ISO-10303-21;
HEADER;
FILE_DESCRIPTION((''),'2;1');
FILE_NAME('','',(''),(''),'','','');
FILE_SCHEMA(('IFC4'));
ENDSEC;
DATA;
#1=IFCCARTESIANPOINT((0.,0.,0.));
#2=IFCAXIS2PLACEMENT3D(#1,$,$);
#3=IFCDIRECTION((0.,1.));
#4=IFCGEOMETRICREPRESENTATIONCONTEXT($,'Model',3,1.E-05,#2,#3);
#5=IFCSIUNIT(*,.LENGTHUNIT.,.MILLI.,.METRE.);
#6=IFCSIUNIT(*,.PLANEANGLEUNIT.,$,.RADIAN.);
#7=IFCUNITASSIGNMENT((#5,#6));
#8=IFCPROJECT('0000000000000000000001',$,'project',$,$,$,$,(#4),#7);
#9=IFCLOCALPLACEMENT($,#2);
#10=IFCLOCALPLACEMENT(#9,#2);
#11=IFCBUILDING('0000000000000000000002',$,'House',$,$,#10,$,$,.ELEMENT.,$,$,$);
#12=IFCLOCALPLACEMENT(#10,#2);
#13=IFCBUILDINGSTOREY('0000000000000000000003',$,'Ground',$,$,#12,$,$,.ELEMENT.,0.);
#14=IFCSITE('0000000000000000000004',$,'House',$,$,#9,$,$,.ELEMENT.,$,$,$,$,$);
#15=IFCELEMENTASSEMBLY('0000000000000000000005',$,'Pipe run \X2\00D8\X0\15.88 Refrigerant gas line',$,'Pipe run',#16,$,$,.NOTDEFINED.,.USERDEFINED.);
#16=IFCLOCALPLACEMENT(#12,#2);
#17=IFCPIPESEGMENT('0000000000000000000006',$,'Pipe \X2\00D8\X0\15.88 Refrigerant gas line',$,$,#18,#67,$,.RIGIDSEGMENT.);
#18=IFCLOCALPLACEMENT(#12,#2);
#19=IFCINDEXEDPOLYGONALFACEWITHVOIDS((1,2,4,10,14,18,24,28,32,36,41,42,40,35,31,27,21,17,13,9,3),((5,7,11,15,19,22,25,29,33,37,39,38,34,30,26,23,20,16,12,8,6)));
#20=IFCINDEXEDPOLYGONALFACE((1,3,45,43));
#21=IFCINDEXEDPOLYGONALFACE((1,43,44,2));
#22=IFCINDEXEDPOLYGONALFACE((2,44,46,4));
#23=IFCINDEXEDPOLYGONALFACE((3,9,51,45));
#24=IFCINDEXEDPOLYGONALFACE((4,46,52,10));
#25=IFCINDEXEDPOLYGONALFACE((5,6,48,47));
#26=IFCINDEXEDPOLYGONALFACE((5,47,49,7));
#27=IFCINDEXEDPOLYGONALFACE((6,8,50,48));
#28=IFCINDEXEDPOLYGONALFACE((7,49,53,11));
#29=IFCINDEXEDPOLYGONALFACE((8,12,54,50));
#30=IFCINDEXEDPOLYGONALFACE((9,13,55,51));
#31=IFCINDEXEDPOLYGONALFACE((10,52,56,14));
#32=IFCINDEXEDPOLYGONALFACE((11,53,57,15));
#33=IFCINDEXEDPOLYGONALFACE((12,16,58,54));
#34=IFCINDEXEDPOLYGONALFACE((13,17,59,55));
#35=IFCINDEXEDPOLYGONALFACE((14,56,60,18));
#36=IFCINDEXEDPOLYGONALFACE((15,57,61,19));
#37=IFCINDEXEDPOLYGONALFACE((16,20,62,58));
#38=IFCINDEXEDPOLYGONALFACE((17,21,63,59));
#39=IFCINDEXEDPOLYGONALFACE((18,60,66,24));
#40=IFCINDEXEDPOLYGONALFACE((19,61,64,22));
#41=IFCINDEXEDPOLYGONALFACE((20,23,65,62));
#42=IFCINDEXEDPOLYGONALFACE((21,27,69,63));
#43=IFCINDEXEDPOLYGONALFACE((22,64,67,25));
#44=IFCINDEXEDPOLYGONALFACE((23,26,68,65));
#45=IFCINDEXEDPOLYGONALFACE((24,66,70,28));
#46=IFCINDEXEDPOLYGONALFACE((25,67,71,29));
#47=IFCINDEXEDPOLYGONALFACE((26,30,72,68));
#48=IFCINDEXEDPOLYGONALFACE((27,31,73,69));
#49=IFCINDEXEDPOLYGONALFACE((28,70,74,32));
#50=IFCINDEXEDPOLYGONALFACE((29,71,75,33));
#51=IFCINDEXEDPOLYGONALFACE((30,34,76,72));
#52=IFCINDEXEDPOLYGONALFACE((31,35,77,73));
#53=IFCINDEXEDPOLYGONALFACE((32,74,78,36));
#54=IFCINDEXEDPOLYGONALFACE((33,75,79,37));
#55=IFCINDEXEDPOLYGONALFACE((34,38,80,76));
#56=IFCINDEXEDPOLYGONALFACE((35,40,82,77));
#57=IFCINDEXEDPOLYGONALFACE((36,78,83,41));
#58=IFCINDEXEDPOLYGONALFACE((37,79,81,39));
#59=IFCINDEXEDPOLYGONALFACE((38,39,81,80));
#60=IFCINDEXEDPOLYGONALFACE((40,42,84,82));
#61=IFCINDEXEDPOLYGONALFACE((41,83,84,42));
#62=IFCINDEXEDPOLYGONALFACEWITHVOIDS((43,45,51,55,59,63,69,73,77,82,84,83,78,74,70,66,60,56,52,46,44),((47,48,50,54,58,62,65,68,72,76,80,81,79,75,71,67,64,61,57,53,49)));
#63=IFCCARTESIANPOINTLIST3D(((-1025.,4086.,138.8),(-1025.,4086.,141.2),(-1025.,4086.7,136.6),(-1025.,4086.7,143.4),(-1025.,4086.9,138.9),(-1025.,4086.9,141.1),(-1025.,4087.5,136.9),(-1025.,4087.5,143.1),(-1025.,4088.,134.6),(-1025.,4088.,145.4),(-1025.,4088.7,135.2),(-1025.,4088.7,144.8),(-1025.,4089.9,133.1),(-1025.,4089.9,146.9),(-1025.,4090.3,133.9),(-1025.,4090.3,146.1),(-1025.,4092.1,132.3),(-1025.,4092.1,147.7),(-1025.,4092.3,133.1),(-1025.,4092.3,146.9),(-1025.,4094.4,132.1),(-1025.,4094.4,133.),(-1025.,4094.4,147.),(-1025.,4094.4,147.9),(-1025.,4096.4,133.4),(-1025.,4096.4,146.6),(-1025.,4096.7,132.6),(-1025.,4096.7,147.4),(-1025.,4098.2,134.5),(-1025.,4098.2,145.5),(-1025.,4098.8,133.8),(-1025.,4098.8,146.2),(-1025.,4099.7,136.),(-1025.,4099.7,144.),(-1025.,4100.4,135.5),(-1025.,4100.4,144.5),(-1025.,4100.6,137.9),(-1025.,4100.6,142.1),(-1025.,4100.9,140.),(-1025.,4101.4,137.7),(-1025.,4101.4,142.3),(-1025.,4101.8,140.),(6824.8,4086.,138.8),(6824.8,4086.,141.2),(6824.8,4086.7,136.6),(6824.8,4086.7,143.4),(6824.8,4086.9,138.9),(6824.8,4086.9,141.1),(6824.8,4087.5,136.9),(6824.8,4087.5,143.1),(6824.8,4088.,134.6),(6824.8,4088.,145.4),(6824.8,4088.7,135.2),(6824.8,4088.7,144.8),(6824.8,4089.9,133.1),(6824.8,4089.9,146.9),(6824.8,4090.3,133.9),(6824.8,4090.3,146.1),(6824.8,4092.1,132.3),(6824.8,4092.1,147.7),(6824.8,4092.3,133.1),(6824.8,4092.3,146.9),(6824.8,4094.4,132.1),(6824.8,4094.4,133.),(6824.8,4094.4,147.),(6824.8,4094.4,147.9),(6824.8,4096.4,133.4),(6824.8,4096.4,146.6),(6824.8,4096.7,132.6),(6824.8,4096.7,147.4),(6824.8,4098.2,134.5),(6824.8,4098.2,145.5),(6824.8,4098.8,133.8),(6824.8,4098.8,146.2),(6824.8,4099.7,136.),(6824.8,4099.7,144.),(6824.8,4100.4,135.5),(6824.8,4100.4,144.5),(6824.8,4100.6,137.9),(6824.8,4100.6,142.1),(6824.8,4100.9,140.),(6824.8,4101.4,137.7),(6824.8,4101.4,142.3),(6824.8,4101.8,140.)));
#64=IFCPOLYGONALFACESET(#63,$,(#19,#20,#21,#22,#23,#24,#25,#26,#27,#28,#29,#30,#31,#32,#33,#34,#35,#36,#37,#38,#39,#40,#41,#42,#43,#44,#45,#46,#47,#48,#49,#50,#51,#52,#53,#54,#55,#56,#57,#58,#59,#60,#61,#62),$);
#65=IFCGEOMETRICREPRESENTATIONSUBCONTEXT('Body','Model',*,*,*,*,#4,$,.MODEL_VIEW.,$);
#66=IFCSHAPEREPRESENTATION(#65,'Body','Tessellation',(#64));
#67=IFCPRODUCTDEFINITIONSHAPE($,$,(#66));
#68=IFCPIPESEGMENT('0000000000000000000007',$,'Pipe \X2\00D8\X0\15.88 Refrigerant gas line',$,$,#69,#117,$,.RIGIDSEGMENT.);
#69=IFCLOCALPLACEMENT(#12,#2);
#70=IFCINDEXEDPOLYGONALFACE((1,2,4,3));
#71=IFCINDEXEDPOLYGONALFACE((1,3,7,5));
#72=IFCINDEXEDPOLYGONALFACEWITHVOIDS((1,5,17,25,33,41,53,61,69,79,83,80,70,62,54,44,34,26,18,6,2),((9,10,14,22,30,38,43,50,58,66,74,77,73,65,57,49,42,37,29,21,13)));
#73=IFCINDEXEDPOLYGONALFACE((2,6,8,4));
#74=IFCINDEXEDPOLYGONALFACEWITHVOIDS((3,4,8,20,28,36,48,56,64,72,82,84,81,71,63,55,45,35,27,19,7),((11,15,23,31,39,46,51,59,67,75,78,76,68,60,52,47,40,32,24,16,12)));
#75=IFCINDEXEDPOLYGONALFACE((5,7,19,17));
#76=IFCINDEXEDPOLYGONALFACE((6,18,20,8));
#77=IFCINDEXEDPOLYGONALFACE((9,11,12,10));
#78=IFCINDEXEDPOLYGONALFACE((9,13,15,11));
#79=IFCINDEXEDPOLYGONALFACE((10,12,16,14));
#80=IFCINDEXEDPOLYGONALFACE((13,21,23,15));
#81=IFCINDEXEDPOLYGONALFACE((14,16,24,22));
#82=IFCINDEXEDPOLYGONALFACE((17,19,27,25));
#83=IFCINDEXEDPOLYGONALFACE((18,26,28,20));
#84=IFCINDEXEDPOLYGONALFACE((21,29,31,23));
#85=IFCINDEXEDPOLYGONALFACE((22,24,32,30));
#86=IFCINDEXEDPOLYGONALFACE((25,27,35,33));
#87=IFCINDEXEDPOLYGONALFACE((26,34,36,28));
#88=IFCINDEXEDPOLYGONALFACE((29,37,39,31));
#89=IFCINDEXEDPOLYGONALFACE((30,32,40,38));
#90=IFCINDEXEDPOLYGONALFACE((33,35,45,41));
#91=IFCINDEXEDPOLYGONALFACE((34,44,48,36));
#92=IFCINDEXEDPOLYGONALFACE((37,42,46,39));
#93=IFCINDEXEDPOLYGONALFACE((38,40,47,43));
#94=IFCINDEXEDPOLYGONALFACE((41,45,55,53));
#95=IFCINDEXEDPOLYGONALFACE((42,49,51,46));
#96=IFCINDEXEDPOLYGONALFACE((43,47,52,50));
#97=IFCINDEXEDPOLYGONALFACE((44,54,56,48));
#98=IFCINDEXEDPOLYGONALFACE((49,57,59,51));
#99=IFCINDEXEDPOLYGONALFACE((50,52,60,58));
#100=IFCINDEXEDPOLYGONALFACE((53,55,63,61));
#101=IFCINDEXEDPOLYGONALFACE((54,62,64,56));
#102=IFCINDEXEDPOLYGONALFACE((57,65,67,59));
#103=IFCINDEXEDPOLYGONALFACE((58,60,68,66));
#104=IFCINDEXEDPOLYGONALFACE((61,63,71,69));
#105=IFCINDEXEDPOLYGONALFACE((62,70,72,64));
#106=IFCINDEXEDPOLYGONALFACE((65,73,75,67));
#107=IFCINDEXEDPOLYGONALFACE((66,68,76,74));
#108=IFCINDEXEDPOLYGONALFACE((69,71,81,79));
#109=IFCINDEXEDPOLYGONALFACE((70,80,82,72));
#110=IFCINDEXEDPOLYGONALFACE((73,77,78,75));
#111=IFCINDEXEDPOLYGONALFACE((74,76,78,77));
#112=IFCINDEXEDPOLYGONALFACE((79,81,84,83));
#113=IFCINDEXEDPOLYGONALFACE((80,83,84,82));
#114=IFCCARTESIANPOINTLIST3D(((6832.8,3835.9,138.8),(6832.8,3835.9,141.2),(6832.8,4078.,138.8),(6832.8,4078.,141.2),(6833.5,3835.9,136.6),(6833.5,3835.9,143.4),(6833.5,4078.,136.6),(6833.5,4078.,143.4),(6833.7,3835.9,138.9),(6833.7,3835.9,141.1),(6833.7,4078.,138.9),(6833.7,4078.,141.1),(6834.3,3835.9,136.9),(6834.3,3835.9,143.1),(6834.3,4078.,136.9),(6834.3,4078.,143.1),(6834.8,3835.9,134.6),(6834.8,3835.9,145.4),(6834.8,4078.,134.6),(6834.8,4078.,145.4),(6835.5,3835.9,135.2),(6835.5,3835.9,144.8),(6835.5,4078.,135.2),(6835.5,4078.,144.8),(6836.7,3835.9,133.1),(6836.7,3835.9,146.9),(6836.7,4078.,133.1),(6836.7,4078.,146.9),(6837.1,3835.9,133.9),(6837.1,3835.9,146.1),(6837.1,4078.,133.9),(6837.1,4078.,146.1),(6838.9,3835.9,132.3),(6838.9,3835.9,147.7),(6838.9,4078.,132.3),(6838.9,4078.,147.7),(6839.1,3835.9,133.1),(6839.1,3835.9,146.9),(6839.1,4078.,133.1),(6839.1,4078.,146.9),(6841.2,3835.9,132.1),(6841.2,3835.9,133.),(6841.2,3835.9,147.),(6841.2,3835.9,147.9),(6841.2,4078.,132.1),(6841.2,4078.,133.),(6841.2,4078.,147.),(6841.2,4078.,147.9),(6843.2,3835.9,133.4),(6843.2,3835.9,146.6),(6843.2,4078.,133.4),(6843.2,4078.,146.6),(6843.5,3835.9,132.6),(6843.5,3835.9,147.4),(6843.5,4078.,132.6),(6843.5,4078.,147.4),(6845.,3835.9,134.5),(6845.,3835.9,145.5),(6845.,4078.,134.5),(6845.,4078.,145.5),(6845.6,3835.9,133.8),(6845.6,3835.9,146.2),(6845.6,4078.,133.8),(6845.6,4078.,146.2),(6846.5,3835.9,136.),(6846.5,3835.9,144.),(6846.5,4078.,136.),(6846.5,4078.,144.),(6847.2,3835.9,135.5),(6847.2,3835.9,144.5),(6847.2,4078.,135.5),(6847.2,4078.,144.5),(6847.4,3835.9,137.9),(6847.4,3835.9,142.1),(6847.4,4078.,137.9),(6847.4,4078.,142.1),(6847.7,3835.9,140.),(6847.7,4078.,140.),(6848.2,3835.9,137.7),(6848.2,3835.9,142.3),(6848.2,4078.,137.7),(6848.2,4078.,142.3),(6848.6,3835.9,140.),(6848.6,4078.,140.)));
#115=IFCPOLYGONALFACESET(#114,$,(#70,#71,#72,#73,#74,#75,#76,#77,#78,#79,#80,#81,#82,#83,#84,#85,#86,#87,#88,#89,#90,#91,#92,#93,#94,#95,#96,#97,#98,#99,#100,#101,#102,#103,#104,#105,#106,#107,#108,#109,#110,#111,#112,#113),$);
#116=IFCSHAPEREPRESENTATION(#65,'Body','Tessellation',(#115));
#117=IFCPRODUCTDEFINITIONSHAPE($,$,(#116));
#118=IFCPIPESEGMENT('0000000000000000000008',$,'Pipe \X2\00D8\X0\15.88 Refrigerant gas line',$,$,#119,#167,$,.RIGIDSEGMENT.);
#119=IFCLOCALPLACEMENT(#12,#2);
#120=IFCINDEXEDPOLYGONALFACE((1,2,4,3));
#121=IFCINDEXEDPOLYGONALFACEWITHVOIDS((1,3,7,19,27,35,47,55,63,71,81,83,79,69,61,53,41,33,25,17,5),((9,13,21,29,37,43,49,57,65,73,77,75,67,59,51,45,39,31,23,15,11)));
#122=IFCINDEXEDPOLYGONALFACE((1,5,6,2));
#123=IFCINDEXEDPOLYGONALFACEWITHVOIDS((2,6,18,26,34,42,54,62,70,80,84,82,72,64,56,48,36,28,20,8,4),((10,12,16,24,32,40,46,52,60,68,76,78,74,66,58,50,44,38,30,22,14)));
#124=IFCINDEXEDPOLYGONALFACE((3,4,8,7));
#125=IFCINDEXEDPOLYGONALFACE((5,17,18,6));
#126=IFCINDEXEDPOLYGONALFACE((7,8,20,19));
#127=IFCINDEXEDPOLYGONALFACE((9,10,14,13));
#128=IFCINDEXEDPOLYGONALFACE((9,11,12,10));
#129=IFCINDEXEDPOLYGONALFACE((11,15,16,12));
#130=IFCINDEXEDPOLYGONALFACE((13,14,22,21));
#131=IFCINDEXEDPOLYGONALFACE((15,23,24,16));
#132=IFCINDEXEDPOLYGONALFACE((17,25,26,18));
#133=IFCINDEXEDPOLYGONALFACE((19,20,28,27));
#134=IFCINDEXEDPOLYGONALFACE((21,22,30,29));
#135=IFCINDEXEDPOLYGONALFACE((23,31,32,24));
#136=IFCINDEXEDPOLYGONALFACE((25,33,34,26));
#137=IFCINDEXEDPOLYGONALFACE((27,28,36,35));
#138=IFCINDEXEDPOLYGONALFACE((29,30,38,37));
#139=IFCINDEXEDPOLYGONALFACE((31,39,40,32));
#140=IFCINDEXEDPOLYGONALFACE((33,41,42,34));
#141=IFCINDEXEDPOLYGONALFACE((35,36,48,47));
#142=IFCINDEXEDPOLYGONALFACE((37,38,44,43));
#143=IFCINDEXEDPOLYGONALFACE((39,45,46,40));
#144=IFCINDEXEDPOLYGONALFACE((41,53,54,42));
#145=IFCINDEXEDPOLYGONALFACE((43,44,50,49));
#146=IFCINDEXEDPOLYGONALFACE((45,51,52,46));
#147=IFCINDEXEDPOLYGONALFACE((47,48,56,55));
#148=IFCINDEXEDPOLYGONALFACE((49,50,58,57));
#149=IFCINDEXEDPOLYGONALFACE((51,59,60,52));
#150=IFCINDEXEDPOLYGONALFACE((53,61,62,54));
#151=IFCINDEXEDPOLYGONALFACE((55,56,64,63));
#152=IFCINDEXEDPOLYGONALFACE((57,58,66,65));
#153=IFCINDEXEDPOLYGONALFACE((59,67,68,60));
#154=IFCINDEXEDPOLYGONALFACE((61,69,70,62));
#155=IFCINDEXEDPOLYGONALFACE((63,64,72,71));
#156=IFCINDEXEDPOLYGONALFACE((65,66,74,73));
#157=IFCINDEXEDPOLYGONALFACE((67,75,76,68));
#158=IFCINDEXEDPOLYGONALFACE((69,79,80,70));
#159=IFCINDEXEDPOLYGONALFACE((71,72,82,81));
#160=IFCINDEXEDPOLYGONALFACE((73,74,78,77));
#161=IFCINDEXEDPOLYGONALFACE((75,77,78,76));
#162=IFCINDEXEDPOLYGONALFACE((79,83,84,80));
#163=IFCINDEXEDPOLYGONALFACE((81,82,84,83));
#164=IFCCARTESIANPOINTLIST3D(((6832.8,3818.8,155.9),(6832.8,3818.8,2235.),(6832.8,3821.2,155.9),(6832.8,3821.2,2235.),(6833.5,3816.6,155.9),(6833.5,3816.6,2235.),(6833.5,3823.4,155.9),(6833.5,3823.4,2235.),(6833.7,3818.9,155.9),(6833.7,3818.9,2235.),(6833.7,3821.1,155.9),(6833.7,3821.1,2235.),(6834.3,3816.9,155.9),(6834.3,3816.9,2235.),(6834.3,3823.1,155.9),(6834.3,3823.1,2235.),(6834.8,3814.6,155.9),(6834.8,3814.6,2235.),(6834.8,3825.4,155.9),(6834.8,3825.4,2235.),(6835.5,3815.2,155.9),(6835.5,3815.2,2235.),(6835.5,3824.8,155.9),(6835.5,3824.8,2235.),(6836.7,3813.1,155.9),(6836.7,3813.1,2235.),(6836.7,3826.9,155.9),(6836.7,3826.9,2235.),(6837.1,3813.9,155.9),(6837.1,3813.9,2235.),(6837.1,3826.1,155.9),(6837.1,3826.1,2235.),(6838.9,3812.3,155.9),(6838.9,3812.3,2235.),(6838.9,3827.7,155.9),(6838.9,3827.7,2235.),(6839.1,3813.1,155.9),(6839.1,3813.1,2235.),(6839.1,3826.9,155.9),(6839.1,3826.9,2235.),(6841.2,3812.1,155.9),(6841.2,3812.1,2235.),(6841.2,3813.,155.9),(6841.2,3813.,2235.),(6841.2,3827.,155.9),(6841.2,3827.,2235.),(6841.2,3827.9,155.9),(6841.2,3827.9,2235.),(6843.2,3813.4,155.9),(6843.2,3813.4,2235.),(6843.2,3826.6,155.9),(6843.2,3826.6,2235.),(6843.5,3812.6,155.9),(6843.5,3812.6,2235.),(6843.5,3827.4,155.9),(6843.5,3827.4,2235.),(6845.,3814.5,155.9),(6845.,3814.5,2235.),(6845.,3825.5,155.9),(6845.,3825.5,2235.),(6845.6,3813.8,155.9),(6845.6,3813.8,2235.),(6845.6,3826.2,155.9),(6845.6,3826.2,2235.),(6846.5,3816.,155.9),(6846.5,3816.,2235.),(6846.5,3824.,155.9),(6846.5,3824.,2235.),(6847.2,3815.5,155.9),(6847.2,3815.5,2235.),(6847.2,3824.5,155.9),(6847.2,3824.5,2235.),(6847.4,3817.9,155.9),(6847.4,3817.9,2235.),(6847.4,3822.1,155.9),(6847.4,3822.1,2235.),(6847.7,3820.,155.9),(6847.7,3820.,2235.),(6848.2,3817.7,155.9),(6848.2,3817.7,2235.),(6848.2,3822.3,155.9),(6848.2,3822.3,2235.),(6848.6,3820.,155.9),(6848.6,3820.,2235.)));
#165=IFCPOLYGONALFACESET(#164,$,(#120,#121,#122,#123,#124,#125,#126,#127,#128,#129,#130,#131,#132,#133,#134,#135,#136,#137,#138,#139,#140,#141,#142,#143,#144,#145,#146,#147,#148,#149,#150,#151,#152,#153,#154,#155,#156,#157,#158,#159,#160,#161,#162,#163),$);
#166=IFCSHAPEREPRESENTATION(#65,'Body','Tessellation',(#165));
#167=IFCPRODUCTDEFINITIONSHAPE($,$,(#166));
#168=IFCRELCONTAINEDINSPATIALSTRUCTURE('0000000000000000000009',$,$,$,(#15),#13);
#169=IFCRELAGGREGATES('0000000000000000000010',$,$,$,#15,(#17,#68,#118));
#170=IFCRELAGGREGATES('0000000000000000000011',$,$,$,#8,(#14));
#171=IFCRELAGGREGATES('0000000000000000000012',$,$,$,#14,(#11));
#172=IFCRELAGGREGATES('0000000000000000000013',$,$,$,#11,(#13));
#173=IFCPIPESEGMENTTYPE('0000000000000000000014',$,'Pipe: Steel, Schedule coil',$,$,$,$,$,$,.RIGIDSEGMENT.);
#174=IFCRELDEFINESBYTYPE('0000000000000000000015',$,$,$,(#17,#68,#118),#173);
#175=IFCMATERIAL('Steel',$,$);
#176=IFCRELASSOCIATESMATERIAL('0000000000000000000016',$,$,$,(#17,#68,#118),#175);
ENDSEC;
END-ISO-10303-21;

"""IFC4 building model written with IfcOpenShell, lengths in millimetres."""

from ifc_helpers import new_model, si_unit, direction, frame, origin, origin_with_axes, origin_2d, place, context, subcontext, project, spatial, hollow_circle, extrude, material, type_object, element, aggregate, save


model = new_model("IFC4")

# Units and contexts
model_context = context("Model", 3, precision=1e-05, world=origin(), true_north=direction((0.0, 1.0)))
body_context = subcontext(model_context, "Body", "Model", "MODEL_VIEW")
ifc_project = project(units=[si_unit("LENGTHUNIT", "METRE", prefix="MILLI"), si_unit("PLANEANGLEUNIT", "RADIAN")], contexts=[model_context])

# Site, building, storey
site_placement = place(None, origin())
site = spatial("IfcSite", under=ifc_project, at=site_placement, Name="House", CompositionType="ELEMENT")
building_placement = place(site_placement, origin())
building = spatial("IfcBuilding", under=site, at=building_placement, Name="House", CompositionType="ELEMENT")
storey_placement = place(building_placement, origin())
storey = spatial("IfcBuildingStorey", under=building, at=storey_placement, Name="Ground", CompositionType="ELEMENT", Elevation=0.0)

# Element assembly, pipe segments
ifc_material = material(Name="Steel")
pipe_segment_type = type_object("IfcPipeSegmentType", Name="Pipe: Steel, Schedule coil", PredefinedType="RIGIDSEGMENT")
assembly_1_placement = place(storey_placement, origin_with_axes())
assembly_1 = element("IfcElementAssembly", 1, at=assembly_1_placement, inside=storey, Name="Pipe run Ø15.88 Refrigerant gas line", ObjectType="Pipe run", AssemblyPlace="NOTDEFINED", PredefinedType="USERDEFINED")
pipe_segment_1_placement = place(storey_placement, origin_with_axes())
pipe_segment_1 = element("IfcPipeSegment", 2, at=pipe_segment_1_placement, type_object=pipe_segment_type, material=ifc_material, Name="Pipe Ø15.88 Refrigerant gas line", PredefinedType="RIGIDSEGMENT", context=body_context, shape_type="SweptSolid", body=[
    extrude(hollow_circle(Radius=7.9, WallThickness=0.9, at=origin_2d()), frame((-1025.0, 4093.8, 140.0), z_axis=(1.0, 0.0, 0.0), x_axis=(0.0, 1.0, 0.0)), (0.0, 0.0, 1.0), 7849.8),
])
pipe_segment_2_placement = place(storey_placement, origin_with_axes())
pipe_segment_2 = element("IfcPipeSegment", 3, at=pipe_segment_2_placement, type_object=pipe_segment_type, material=ifc_material, Name="Pipe Ø15.88 Refrigerant gas line", PredefinedType="RIGIDSEGMENT", context=body_context, shape_type="SweptSolid", body=[
    extrude(hollow_circle(Radius=7.9, WallThickness=0.9, at=origin_2d()), frame((6840.6, 4078.0, 140.0), z_axis=(0.0, -1.0, 0.0), x_axis=(1.0, 0.0, 0.0)), (0.0, 0.0, 1.0), 242.1),
])
pipe_segment_3_placement = place(storey_placement, origin_with_axes())
pipe_segment_3 = element("IfcPipeSegment", 4, at=pipe_segment_3_placement, type_object=pipe_segment_type, material=ifc_material, Name="Pipe Ø15.88 Refrigerant gas line", PredefinedType="RIGIDSEGMENT", context=body_context, shape_type="SweptSolid", body=[
    extrude(hollow_circle(Radius=7.9, WallThickness=0.9, at=origin_2d()), frame((6840.6, 3820.0, 155.9), z_axis=(0.0, 0.0, 1.0), x_axis=(1.0, 0.0, 0.0)), (0.0, 0.0, 1.0), 2079.1),
])

aggregate(assembly_1, [pipe_segment_1, pipe_segment_2, pipe_segment_3])

save(model, "model.ifc")
